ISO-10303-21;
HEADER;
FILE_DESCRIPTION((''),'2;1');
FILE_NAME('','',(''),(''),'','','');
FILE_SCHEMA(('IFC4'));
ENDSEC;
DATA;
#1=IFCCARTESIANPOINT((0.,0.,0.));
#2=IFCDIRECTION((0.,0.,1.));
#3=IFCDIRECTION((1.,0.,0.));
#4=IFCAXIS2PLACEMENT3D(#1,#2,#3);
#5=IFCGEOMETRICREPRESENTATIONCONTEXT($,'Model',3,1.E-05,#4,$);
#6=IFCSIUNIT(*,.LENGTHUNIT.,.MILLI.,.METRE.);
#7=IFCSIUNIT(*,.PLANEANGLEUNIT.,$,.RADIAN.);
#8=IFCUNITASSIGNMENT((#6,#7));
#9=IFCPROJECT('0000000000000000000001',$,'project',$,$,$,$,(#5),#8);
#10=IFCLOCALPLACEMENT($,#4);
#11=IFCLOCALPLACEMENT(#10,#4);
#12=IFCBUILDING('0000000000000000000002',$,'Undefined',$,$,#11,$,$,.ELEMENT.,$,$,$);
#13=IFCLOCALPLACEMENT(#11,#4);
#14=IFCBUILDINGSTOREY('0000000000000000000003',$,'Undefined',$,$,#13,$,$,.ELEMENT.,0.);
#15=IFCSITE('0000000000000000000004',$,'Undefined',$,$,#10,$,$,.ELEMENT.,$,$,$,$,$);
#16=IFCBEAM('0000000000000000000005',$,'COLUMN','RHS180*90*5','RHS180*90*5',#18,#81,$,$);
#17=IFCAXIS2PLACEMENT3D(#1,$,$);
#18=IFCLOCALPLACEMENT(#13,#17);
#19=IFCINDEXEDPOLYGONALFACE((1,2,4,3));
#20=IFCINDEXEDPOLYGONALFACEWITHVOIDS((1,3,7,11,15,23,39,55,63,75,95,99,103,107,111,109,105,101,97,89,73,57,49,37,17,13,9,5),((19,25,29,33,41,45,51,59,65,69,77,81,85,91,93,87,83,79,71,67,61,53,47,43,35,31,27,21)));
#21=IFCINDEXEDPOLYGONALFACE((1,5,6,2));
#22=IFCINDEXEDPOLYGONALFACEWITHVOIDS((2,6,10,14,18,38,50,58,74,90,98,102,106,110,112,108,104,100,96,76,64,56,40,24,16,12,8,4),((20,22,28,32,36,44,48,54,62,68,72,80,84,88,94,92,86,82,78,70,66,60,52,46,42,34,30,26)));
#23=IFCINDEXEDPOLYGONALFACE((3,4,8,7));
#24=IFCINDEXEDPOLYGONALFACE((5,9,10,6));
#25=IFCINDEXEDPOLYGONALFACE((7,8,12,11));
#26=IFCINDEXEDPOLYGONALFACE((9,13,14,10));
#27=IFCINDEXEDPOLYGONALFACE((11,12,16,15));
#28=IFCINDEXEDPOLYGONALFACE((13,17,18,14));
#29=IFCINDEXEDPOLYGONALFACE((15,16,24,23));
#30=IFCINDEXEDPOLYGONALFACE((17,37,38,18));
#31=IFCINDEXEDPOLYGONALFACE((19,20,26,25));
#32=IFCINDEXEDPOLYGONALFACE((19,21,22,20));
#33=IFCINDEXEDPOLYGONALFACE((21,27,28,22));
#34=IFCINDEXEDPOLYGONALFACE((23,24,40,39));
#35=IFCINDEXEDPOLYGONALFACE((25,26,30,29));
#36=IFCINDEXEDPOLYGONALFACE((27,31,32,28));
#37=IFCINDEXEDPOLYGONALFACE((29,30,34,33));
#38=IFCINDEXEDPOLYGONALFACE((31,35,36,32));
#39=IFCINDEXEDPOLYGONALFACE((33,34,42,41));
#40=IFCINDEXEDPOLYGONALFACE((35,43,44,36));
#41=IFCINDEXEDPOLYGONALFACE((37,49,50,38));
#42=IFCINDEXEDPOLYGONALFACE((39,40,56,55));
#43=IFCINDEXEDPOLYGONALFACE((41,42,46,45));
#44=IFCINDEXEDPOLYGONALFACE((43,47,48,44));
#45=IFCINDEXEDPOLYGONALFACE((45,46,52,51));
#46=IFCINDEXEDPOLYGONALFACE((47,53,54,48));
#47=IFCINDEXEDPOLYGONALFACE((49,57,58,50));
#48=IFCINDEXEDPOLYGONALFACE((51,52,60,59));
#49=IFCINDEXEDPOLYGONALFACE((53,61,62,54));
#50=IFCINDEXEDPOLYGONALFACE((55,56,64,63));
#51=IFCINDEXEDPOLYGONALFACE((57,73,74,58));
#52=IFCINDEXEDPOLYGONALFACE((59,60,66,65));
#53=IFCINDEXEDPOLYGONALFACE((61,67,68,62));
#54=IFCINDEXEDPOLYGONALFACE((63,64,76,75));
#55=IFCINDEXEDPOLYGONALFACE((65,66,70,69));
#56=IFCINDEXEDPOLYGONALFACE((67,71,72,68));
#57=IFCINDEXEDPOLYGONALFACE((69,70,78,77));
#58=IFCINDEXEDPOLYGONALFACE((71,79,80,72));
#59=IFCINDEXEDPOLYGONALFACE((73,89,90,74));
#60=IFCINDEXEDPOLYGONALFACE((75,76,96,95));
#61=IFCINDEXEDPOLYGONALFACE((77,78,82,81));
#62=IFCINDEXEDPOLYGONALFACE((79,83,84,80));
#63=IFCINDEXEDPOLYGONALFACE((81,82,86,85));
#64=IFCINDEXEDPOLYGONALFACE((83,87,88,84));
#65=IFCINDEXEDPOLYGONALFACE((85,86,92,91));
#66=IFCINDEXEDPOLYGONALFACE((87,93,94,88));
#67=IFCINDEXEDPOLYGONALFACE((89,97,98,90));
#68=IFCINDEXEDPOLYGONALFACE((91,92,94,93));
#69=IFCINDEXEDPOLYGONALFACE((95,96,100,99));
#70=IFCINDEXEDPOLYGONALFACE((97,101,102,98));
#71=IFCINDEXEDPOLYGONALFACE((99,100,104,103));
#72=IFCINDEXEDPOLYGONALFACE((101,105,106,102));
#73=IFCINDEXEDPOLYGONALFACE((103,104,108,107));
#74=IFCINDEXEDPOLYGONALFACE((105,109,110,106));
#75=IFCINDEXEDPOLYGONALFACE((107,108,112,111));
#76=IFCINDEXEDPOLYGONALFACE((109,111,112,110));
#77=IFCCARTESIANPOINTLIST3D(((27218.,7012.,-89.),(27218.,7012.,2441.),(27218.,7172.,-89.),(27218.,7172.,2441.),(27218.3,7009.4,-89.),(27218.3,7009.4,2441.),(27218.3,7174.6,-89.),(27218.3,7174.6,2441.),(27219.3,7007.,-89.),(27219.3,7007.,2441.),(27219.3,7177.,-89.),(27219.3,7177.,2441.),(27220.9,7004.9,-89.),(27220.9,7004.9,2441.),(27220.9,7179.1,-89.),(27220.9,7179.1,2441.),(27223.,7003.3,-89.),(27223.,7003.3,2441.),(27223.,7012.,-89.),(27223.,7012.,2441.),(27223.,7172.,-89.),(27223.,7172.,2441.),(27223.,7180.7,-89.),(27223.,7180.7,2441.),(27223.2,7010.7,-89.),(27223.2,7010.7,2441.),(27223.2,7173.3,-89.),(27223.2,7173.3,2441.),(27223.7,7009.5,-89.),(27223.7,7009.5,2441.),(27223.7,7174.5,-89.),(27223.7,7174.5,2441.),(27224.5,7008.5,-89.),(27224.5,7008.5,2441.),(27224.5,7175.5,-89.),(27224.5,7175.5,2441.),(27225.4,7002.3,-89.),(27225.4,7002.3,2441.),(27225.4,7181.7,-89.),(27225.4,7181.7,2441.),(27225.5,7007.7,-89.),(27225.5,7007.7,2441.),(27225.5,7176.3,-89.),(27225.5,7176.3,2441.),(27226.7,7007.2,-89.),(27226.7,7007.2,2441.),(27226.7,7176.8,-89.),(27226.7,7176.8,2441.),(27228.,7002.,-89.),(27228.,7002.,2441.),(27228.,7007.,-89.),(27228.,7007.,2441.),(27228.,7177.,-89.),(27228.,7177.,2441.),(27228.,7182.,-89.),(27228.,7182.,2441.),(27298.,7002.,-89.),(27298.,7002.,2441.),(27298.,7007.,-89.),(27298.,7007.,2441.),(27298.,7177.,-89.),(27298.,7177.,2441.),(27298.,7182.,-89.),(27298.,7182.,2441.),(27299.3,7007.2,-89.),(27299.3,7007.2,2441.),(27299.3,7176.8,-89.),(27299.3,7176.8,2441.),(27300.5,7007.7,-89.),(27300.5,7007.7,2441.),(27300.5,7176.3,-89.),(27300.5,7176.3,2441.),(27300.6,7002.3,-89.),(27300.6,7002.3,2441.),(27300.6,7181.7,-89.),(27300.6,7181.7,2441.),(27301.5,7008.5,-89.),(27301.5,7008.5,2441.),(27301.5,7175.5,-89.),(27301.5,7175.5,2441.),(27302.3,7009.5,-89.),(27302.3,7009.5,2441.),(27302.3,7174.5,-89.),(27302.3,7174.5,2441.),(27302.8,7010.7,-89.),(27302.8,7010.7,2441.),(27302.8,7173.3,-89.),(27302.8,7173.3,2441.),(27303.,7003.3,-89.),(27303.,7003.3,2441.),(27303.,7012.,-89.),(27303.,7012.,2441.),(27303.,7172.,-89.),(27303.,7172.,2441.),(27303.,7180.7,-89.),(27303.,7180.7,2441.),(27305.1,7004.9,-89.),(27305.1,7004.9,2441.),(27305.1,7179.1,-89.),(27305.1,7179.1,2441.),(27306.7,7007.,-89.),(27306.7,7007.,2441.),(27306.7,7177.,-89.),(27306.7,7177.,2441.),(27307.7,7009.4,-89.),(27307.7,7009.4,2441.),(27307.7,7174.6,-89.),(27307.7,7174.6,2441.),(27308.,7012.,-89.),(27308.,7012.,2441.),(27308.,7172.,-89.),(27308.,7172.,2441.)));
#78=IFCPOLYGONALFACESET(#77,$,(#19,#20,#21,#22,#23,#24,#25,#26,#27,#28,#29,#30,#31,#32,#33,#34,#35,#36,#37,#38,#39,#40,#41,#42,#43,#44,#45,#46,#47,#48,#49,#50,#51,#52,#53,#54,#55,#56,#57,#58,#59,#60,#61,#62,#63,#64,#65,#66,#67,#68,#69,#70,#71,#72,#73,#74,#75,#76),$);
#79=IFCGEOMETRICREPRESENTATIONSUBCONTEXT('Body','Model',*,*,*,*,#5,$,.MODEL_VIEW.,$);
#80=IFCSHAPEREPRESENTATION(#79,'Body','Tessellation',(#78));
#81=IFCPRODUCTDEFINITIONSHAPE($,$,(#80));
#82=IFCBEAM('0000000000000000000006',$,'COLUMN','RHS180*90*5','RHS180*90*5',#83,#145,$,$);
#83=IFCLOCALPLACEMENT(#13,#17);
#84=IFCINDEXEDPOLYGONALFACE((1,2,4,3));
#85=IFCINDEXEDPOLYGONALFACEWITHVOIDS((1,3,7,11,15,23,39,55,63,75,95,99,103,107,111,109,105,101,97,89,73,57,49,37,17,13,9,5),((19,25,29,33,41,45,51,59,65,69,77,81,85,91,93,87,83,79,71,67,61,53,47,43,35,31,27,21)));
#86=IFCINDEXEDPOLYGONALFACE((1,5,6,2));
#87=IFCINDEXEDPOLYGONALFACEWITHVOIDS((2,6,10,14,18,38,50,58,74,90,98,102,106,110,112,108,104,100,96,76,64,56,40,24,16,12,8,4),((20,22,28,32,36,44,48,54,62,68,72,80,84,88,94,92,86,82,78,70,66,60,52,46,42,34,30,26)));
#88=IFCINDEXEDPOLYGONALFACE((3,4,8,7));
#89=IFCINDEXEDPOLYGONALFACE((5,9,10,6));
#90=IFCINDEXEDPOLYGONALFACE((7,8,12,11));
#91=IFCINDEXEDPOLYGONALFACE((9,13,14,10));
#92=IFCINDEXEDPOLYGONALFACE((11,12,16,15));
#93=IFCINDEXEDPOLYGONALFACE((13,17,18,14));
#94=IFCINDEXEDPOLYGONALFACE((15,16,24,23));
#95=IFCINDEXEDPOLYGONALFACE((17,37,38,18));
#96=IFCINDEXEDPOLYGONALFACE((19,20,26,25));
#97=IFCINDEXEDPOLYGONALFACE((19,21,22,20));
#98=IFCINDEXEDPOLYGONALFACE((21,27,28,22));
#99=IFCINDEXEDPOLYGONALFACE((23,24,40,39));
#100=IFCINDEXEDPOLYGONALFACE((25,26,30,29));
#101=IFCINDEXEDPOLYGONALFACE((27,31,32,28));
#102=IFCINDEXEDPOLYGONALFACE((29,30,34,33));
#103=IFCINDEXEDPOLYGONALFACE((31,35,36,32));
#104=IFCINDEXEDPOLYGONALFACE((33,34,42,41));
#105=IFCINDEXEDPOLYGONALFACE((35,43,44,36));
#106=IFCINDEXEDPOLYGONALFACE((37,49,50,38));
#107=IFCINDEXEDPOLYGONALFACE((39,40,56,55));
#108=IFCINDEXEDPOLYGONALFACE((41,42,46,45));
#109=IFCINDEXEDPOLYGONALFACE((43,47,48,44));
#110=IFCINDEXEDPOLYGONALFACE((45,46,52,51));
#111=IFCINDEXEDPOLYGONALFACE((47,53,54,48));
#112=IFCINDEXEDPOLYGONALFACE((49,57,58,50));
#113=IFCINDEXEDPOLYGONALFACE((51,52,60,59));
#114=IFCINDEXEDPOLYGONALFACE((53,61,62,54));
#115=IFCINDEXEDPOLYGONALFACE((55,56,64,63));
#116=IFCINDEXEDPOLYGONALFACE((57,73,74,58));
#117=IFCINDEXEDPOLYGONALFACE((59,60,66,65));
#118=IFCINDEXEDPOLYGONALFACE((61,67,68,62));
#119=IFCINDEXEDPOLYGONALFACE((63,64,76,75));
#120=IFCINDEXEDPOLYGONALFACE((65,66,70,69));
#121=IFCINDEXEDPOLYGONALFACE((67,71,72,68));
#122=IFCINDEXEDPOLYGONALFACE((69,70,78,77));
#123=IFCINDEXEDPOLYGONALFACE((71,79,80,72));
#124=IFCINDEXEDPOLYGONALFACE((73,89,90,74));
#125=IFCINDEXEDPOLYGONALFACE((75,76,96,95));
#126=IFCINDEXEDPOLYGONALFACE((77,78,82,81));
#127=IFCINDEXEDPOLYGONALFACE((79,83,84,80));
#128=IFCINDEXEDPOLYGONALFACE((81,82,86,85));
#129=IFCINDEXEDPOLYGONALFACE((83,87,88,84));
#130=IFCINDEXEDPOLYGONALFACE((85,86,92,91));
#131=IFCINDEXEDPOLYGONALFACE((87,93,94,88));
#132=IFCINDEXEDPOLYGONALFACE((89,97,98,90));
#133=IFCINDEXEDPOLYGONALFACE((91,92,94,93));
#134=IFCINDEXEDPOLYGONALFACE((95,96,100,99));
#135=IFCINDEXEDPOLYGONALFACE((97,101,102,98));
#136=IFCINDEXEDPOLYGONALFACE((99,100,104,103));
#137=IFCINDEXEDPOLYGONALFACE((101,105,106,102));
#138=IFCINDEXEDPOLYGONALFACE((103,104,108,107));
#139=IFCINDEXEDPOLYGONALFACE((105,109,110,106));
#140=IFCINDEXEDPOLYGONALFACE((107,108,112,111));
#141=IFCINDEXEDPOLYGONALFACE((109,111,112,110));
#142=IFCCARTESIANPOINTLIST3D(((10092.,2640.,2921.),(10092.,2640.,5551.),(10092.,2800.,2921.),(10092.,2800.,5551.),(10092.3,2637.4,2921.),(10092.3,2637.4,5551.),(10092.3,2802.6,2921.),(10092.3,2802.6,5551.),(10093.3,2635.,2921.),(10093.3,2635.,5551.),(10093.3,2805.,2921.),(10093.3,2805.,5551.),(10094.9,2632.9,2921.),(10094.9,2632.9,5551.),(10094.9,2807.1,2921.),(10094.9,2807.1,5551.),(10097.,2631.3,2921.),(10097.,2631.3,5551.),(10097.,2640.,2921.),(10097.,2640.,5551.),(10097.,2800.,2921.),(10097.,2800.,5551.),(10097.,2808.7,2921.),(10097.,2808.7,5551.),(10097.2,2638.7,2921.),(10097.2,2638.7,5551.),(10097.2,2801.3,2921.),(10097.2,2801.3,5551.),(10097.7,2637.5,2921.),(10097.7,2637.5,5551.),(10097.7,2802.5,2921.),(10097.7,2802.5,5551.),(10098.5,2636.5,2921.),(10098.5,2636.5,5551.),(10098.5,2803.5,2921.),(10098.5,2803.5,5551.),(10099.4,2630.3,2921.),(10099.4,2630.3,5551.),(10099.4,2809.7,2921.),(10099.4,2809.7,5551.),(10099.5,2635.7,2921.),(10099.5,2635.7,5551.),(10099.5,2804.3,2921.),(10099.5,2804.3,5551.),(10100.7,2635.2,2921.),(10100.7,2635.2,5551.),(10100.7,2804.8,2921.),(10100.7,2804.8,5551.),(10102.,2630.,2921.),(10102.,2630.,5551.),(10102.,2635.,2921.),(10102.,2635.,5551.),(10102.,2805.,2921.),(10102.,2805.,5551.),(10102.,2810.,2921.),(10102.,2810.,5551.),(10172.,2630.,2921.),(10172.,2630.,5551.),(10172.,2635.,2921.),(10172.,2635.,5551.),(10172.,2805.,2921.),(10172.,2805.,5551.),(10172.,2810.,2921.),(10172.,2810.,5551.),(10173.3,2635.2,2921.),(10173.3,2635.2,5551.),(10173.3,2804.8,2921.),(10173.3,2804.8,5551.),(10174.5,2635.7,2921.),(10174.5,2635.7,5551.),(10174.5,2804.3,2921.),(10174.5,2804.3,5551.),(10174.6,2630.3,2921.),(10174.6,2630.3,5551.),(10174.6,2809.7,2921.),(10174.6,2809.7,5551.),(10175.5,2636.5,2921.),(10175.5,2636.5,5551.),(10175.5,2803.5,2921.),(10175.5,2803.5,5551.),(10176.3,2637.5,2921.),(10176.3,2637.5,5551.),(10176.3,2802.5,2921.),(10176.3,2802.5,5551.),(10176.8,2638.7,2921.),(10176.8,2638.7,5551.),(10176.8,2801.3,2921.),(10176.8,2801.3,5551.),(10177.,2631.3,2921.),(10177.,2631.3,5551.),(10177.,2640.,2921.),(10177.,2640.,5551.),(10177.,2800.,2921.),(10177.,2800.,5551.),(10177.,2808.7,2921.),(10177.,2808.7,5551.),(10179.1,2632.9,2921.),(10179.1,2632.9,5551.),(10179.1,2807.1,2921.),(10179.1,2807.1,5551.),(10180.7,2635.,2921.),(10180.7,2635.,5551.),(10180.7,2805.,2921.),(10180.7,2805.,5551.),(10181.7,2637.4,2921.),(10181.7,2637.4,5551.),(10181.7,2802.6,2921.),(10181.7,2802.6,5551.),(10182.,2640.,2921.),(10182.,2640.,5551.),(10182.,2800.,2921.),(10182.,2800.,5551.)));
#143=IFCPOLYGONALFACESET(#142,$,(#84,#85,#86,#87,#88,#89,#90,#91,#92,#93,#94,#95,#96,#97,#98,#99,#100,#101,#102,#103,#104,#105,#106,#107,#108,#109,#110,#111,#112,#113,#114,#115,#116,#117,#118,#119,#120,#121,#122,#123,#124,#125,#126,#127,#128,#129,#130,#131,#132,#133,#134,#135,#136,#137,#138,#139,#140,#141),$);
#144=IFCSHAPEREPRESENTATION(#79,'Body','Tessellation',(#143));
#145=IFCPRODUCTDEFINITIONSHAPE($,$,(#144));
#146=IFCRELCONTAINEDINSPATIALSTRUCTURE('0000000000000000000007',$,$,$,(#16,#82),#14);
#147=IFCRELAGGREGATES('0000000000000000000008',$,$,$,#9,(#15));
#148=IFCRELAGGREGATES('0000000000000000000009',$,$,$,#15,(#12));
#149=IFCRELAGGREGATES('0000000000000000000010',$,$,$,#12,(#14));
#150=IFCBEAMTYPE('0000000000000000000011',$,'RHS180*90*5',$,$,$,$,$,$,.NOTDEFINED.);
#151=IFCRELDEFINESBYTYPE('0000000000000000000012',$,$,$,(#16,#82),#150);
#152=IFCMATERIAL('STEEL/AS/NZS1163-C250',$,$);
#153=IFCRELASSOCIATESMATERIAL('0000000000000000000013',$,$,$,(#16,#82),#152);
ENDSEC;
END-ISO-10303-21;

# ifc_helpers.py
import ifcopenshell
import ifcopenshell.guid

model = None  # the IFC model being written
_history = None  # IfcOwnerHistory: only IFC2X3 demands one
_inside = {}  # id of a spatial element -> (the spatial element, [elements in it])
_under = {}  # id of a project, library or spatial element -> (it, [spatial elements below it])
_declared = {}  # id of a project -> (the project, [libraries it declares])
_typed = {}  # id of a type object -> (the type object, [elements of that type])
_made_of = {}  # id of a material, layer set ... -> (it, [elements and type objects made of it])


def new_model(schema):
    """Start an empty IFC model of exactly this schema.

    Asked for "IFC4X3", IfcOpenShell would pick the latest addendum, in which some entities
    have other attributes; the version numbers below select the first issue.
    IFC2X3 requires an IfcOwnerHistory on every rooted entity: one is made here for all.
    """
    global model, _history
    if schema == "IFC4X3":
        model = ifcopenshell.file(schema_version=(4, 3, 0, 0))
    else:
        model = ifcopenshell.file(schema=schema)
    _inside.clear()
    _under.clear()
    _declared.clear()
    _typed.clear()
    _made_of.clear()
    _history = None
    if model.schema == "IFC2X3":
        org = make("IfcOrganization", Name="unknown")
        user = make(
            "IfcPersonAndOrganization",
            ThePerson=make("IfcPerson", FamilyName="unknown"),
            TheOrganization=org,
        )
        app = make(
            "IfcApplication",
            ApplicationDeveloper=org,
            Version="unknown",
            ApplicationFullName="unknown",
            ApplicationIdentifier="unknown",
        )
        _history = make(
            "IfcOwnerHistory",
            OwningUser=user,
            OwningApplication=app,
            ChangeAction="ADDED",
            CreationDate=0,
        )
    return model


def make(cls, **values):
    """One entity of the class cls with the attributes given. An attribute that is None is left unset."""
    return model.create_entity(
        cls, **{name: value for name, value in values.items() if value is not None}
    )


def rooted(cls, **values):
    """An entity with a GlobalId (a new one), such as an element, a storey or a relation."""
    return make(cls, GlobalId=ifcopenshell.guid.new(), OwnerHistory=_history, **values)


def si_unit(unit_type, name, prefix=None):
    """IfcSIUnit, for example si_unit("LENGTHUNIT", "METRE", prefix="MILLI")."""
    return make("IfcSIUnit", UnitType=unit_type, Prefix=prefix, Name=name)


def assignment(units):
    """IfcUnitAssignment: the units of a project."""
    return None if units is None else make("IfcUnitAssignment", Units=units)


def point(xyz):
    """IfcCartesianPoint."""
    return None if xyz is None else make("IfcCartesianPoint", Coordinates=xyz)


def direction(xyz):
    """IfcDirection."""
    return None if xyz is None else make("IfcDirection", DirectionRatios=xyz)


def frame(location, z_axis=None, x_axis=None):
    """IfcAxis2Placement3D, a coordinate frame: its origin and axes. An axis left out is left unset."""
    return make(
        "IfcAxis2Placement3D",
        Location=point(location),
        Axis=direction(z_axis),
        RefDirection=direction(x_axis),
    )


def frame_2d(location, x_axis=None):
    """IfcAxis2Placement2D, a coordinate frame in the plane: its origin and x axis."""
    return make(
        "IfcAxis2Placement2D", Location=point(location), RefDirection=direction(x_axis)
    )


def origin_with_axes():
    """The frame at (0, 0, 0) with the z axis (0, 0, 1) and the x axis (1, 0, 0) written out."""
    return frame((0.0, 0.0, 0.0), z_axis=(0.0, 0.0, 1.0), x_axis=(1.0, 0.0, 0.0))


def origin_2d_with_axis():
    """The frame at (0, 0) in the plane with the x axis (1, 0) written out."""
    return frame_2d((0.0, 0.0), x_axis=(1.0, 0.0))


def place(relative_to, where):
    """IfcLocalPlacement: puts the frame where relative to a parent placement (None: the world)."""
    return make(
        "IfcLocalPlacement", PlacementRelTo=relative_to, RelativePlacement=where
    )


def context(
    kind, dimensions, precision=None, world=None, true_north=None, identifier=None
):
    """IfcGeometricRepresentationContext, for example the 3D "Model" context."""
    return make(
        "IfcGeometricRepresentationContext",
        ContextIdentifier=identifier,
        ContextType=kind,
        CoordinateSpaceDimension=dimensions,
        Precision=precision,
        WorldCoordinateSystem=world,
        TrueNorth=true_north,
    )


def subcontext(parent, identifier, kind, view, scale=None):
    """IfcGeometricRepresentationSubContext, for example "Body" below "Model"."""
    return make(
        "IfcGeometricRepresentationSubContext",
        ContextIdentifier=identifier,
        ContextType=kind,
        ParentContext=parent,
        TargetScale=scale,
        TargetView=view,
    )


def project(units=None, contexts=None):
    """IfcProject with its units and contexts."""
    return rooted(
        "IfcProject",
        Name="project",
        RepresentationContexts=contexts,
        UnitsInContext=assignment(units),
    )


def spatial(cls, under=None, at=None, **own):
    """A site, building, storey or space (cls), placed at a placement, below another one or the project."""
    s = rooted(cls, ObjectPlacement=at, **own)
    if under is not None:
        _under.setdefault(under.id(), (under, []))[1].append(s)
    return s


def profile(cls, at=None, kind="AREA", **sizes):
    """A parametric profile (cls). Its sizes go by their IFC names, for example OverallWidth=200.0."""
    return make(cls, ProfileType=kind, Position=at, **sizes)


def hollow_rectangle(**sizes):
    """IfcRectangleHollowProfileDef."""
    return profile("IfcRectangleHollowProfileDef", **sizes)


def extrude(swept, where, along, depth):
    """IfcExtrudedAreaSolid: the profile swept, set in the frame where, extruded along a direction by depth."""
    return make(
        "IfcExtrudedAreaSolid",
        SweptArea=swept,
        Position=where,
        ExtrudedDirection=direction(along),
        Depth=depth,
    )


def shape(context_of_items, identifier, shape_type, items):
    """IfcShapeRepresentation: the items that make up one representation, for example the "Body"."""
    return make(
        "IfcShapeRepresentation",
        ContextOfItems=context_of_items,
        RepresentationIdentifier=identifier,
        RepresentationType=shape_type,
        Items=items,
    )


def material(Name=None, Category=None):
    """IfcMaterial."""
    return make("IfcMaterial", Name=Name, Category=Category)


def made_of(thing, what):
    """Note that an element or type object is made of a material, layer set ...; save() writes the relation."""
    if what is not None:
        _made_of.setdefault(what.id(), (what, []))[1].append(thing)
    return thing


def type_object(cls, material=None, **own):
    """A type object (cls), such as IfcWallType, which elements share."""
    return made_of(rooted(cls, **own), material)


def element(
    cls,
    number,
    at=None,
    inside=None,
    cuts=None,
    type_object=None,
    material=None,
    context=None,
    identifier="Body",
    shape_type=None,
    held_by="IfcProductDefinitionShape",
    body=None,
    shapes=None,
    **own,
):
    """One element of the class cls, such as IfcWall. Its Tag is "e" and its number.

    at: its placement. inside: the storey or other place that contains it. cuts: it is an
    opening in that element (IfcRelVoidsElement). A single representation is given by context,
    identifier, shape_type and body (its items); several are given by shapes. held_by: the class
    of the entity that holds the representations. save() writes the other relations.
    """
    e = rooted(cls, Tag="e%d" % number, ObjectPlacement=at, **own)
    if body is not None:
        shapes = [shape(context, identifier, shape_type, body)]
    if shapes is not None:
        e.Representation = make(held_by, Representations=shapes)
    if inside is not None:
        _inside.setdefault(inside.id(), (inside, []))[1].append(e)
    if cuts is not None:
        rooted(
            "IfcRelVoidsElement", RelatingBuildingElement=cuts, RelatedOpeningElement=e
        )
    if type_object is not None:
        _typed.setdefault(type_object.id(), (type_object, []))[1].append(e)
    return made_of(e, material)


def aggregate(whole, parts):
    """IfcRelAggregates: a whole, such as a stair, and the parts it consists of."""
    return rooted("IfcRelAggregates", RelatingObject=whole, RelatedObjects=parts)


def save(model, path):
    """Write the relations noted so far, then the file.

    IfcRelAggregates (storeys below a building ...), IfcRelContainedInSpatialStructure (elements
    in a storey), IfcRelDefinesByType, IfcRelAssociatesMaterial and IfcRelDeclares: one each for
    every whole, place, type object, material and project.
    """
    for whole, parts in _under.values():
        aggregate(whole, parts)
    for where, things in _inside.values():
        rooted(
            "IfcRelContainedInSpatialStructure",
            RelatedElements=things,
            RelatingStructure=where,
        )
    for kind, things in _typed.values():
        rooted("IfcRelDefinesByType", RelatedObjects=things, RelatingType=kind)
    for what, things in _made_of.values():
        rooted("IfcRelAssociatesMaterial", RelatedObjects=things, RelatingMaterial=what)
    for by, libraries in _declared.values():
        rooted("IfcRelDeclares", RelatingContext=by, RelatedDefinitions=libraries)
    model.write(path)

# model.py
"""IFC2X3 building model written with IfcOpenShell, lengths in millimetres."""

from ifc_helpers import new_model, si_unit, frame, origin_with_axes, origin_2d_with_axis, place, context, subcontext, project, spatial, hollow_rectangle, extrude, material, type_object, element, save


model = new_model("IFC2X3")

# Units and contexts
model_context = context("Model", 3, precision=1e-05, world=origin_with_axes())
body_context = subcontext(model_context, "Body", "Model", "MODEL_VIEW")
ifc_project = project(units=[si_unit("LENGTHUNIT", "METRE", prefix="MILLI"), si_unit("PLANEANGLEUNIT", "RADIAN")], contexts=[model_context])

# Site, building, storey
site_placement = place(None, origin_with_axes())
site = spatial("IfcSite", under=ifc_project, at=site_placement, Name="Undefined", CompositionType="ELEMENT")
building_placement = place(site_placement, origin_with_axes())
building = spatial("IfcBuilding", under=site, at=building_placement, Name="Undefined", CompositionType="ELEMENT")
storey_placement = place(building_placement, origin_with_axes())
storey = spatial("IfcBuildingStorey", under=building, at=storey_placement, Name="Undefined", CompositionType="ELEMENT", Elevation=0.0)

# Shared definitions
ifc_material_1 = material(Name="STEEL/AS/NZS1163-C250")

# Beams
beam_type_1 = type_object("IfcBeamType", Name="RHS180*90*5", PredefinedType="NOTDEFINED")
beam_1_placement = place(storey_placement, frame((27263.0, 7092.0, 2441.0), z_axis=(0.0, 1.0, 0.0), x_axis=(0.0, 0.0, -1.0)))
element("IfcBeam", 1, at=beam_1_placement, inside=storey, type_object=beam_type_1, material=ifc_material_1, Name="COLUMN", Description="RHS180*90*5", ObjectType="RHS180*90*5", context=body_context, shape_type="SweptSolid", body=[
    extrude(hollow_rectangle(XDim=90.0, YDim=180.0, WallThickness=5.0, InnerFilletRadius=5.0, OuterFilletRadius=10.0, at=origin_2d_with_axis()), frame((2530.0, 0.0, 0.0), z_axis=(-1.0, 0.0, 0.0), x_axis=(0.0, -1.0, 0.0)), (0.0, 0.0, 1.0), 2530.0),
])
beam_2_placement = place(storey_placement, frame((10137.0, 2720.0, 5551.0), z_axis=(0.0, 1.0, 0.0), x_axis=(0.0, 0.0, -1.0)))
element("IfcBeam", 2, at=beam_2_placement, inside=storey, type_object=beam_type_1, material=ifc_material_1, Name="COLUMN", Description="RHS180*90*5", ObjectType="RHS180*90*5", context=body_context, shape_type="SweptSolid", body=[
    extrude(hollow_rectangle(XDim=90.0, YDim=180.0, WallThickness=5.0, InnerFilletRadius=5.0, OuterFilletRadius=10.0, at=origin_2d_with_axis()), frame((2630.0, 0.0, 0.0), z_axis=(-1.0, 0.0, 0.0), x_axis=(0.0, -1.0, 0.0)), (0.0, 0.0, 1.0), 2630.0),
])

save(model, "model.ifc")
